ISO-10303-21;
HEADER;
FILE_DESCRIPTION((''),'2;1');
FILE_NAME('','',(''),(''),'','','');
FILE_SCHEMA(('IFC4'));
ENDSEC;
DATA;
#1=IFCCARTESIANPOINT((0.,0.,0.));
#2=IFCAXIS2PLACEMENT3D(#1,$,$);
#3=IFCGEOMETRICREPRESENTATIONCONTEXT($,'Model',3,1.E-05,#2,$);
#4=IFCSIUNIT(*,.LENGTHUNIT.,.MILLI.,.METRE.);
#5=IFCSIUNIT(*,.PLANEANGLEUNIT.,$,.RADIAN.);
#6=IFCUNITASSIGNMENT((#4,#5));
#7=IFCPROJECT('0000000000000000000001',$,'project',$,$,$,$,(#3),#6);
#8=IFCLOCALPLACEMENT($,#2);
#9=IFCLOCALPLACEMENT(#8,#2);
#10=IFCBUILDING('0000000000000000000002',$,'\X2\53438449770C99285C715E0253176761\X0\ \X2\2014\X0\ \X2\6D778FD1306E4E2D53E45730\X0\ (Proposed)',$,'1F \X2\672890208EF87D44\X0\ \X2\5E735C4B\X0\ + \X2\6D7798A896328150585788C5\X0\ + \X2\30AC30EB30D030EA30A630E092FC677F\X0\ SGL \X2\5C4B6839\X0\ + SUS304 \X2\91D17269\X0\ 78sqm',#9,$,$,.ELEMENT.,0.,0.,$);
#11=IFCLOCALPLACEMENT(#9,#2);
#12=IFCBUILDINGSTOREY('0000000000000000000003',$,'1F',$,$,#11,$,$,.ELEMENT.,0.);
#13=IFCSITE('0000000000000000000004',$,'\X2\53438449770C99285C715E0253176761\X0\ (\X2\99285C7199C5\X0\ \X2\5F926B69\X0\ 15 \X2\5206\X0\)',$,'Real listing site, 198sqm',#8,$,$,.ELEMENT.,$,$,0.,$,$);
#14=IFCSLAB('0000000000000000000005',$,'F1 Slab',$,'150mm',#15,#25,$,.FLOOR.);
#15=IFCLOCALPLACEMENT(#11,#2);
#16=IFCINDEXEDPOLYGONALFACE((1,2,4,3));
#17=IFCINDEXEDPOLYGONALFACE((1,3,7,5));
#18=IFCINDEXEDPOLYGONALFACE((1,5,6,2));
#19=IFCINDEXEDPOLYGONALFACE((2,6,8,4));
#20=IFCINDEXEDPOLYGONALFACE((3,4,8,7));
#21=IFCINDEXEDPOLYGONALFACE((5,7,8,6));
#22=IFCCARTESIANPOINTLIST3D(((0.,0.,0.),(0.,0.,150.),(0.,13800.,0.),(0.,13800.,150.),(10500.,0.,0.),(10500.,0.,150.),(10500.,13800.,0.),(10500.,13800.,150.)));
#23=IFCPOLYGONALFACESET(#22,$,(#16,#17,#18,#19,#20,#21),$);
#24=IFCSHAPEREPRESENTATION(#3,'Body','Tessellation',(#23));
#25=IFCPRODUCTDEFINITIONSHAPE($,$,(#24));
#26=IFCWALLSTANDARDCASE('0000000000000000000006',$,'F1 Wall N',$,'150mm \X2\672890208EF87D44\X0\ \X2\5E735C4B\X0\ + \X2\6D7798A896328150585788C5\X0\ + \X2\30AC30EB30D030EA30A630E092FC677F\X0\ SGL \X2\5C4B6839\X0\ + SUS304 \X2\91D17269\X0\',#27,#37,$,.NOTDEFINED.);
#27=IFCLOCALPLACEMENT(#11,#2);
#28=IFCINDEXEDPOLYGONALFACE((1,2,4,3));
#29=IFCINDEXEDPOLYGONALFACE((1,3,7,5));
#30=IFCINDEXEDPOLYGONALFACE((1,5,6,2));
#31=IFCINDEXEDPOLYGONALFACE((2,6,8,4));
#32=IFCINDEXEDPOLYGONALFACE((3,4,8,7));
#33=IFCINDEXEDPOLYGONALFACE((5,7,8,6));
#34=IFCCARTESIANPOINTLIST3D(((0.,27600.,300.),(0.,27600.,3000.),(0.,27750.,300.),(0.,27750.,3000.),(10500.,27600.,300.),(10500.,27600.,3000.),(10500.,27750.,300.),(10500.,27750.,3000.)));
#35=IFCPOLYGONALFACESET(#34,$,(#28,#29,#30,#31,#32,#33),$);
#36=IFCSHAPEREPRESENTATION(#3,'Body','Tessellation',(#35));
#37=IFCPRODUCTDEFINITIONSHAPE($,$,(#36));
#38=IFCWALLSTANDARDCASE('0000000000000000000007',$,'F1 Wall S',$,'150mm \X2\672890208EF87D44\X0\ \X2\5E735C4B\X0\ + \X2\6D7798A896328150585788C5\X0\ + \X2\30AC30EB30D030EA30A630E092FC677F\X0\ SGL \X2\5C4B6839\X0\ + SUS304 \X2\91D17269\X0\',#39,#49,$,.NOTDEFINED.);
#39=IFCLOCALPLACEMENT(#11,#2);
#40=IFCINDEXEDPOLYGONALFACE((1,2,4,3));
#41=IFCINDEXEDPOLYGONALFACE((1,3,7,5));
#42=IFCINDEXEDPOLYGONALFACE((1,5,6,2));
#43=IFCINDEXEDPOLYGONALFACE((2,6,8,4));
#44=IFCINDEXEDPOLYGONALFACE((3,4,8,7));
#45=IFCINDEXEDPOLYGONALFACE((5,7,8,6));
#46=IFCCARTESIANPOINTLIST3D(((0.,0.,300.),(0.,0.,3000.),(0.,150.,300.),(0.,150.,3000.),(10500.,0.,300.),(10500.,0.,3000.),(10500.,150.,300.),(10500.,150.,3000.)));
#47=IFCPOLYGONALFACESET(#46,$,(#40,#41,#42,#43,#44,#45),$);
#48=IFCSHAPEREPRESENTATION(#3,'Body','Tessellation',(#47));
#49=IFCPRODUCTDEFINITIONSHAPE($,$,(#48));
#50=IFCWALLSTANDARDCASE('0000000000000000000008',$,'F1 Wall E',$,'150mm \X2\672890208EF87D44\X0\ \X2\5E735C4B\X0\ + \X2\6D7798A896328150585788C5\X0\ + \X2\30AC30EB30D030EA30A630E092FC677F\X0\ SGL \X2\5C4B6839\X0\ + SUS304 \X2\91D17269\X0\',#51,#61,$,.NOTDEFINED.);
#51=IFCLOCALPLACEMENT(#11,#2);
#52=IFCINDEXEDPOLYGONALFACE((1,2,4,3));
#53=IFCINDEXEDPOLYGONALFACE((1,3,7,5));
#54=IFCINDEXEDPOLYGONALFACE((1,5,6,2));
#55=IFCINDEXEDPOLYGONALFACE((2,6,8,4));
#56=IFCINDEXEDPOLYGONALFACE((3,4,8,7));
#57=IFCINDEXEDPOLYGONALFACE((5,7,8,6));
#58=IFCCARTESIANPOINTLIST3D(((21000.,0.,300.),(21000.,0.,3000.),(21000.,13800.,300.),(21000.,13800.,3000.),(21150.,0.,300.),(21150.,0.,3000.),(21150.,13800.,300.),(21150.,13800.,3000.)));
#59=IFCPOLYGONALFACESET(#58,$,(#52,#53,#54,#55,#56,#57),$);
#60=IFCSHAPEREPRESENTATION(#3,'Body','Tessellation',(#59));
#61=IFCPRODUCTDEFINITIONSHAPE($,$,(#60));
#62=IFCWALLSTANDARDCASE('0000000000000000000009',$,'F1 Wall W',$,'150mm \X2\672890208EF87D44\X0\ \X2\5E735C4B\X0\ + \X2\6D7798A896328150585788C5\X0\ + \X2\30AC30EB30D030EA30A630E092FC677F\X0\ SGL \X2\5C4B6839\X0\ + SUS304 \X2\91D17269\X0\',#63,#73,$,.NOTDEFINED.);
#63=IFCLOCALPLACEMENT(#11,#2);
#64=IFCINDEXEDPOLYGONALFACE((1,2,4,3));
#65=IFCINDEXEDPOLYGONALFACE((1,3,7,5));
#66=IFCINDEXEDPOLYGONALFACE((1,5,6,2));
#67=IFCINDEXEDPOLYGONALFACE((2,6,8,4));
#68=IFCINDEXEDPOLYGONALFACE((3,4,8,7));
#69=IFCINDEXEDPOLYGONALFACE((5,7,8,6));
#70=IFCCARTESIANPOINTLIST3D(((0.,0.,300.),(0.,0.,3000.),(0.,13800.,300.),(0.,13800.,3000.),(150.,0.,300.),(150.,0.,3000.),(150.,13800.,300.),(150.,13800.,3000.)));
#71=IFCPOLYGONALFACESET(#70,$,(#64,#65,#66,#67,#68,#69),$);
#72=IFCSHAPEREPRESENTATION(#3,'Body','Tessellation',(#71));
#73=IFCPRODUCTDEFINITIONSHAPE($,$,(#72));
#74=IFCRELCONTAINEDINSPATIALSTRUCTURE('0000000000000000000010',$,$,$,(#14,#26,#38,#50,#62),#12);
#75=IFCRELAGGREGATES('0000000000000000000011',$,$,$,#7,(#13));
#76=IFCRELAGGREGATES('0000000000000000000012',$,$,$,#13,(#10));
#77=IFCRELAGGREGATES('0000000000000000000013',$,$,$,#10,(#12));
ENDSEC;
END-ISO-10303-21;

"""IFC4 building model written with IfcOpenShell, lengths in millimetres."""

from ifc_helpers import new_model, si_unit, frame, frame_2d, origin, place, context, project, spatial, rectangle, extrude, element, save


model = new_model("IFC4")

# Units and contexts
model_context = context("Model", 3, precision=1e-05, world=origin())
ifc_project = project(units=[si_unit("LENGTHUNIT", "METRE", prefix="MILLI"), si_unit("PLANEANGLEUNIT", "RADIAN")], contexts=[model_context])

# Site, building, storey
site_placement = place(None, origin())
site = spatial("IfcSite", under=ifc_project, at=site_placement, Name="千葉県館山市北条 (館山駅 徒歩 15 分)", ObjectType="Real listing site, 198sqm", CompositionType="ELEMENT", RefElevation=0.0)
building_placement = place(site_placement, origin())
building = spatial("IfcBuilding", under=site, at=building_placement, Name="千葉県館山市北条 — 海近の中古地 (Proposed)", ObjectType="1F 木造軸組 平屋 + 海風防腐塗装 + ガルバリウム鋼板 SGL 屋根 + SUS304 金物 78sqm", CompositionType="ELEMENT", ElevationOfRefHeight=0.0, ElevationOfTerrain=0.0)
storey_placement = place(building_placement, origin())
storey = spatial("IfcBuildingStorey", under=building, at=storey_placement, Name="1F", CompositionType="ELEMENT", Elevation=0.0)

# Slab
slab_placement = place(storey_placement, origin())
element("IfcSlab", 1, at=slab_placement, inside=storey, Name="F1 Slab", ObjectType="150mm", PredefinedType="FLOOR", context=model_context, shape_type="SweptSolid", body=[
    extrude(rectangle(XDim=10500.0, YDim=13800.0, at=frame_2d((5250.0, 6900.0))), origin(), (0.0, 0.0, 1.0), 150.0),
])

# Walls
wall_1_placement = place(storey_placement, frame((0.0, 13800.0, 150.0)))
element("IfcWallStandardCase", 2, at=wall_1_placement, inside=storey, Name="F1 Wall N", ObjectType="150mm 木造軸組 平屋 + 海風防腐塗装 + ガルバリウム鋼板 SGL 屋根 + SUS304 金物", PredefinedType="NOTDEFINED", context=model_context, shape_type="SweptSolid", body=[
    extrude(rectangle(XDim=10500.0, YDim=150.0, at=frame_2d((5250.0, 75.0))), frame((0.0, 13800.0, 150.0)), (0.0, 0.0, 1.0), 2700.0),
])
wall_2_placement = place(storey_placement, frame((0.0, 0.0, 150.0)))
element("IfcWallStandardCase", 3, at=wall_2_placement, inside=storey, Name="F1 Wall S", ObjectType="150mm 木造軸組 平屋 + 海風防腐塗装 + ガルバリウム鋼板 SGL 屋根 + SUS304 金物", PredefinedType="NOTDEFINED", context=model_context, shape_type="SweptSolid", body=[
    extrude(rectangle(XDim=10500.0, YDim=150.0, at=frame_2d((5250.0, 75.0))), frame((0.0, 0.0, 150.0)), (0.0, 0.0, 1.0), 2700.0),
])
wall_3_placement = place(storey_placement, frame((10500.0, 0.0, 150.0)))
element("IfcWallStandardCase", 4, at=wall_3_placement, inside=storey, Name="F1 Wall E", ObjectType="150mm 木造軸組 平屋 + 海風防腐塗装 + ガルバリウム鋼板 SGL 屋根 + SUS304 金物", PredefinedType="NOTDEFINED", context=model_context, shape_type="SweptSolid", body=[
    extrude(rectangle(XDim=150.0, YDim=13800.0, at=frame_2d((75.0, 6900.0))), frame((10500.0, 0.0, 150.0)), (0.0, 0.0, 1.0), 2700.0),
])
wall_4_placement = place(storey_placement, frame((0.0, 0.0, 150.0)))
element("IfcWallStandardCase", 5, at=wall_4_placement, inside=storey, Name="F1 Wall W", ObjectType="150mm 木造軸組 平屋 + 海風防腐塗装 + ガルバリウム鋼板 SGL 屋根 + SUS304 金物", PredefinedType="NOTDEFINED", context=model_context, shape_type="SweptSolid", body=[
    extrude(rectangle(XDim=150.0, YDim=13800.0, at=frame_2d((75.0, 6900.0))), frame((0.0, 0.0, 150.0)), (0.0, 0.0, 1.0), 2700.0),
])

save(model, "model.ifc")
